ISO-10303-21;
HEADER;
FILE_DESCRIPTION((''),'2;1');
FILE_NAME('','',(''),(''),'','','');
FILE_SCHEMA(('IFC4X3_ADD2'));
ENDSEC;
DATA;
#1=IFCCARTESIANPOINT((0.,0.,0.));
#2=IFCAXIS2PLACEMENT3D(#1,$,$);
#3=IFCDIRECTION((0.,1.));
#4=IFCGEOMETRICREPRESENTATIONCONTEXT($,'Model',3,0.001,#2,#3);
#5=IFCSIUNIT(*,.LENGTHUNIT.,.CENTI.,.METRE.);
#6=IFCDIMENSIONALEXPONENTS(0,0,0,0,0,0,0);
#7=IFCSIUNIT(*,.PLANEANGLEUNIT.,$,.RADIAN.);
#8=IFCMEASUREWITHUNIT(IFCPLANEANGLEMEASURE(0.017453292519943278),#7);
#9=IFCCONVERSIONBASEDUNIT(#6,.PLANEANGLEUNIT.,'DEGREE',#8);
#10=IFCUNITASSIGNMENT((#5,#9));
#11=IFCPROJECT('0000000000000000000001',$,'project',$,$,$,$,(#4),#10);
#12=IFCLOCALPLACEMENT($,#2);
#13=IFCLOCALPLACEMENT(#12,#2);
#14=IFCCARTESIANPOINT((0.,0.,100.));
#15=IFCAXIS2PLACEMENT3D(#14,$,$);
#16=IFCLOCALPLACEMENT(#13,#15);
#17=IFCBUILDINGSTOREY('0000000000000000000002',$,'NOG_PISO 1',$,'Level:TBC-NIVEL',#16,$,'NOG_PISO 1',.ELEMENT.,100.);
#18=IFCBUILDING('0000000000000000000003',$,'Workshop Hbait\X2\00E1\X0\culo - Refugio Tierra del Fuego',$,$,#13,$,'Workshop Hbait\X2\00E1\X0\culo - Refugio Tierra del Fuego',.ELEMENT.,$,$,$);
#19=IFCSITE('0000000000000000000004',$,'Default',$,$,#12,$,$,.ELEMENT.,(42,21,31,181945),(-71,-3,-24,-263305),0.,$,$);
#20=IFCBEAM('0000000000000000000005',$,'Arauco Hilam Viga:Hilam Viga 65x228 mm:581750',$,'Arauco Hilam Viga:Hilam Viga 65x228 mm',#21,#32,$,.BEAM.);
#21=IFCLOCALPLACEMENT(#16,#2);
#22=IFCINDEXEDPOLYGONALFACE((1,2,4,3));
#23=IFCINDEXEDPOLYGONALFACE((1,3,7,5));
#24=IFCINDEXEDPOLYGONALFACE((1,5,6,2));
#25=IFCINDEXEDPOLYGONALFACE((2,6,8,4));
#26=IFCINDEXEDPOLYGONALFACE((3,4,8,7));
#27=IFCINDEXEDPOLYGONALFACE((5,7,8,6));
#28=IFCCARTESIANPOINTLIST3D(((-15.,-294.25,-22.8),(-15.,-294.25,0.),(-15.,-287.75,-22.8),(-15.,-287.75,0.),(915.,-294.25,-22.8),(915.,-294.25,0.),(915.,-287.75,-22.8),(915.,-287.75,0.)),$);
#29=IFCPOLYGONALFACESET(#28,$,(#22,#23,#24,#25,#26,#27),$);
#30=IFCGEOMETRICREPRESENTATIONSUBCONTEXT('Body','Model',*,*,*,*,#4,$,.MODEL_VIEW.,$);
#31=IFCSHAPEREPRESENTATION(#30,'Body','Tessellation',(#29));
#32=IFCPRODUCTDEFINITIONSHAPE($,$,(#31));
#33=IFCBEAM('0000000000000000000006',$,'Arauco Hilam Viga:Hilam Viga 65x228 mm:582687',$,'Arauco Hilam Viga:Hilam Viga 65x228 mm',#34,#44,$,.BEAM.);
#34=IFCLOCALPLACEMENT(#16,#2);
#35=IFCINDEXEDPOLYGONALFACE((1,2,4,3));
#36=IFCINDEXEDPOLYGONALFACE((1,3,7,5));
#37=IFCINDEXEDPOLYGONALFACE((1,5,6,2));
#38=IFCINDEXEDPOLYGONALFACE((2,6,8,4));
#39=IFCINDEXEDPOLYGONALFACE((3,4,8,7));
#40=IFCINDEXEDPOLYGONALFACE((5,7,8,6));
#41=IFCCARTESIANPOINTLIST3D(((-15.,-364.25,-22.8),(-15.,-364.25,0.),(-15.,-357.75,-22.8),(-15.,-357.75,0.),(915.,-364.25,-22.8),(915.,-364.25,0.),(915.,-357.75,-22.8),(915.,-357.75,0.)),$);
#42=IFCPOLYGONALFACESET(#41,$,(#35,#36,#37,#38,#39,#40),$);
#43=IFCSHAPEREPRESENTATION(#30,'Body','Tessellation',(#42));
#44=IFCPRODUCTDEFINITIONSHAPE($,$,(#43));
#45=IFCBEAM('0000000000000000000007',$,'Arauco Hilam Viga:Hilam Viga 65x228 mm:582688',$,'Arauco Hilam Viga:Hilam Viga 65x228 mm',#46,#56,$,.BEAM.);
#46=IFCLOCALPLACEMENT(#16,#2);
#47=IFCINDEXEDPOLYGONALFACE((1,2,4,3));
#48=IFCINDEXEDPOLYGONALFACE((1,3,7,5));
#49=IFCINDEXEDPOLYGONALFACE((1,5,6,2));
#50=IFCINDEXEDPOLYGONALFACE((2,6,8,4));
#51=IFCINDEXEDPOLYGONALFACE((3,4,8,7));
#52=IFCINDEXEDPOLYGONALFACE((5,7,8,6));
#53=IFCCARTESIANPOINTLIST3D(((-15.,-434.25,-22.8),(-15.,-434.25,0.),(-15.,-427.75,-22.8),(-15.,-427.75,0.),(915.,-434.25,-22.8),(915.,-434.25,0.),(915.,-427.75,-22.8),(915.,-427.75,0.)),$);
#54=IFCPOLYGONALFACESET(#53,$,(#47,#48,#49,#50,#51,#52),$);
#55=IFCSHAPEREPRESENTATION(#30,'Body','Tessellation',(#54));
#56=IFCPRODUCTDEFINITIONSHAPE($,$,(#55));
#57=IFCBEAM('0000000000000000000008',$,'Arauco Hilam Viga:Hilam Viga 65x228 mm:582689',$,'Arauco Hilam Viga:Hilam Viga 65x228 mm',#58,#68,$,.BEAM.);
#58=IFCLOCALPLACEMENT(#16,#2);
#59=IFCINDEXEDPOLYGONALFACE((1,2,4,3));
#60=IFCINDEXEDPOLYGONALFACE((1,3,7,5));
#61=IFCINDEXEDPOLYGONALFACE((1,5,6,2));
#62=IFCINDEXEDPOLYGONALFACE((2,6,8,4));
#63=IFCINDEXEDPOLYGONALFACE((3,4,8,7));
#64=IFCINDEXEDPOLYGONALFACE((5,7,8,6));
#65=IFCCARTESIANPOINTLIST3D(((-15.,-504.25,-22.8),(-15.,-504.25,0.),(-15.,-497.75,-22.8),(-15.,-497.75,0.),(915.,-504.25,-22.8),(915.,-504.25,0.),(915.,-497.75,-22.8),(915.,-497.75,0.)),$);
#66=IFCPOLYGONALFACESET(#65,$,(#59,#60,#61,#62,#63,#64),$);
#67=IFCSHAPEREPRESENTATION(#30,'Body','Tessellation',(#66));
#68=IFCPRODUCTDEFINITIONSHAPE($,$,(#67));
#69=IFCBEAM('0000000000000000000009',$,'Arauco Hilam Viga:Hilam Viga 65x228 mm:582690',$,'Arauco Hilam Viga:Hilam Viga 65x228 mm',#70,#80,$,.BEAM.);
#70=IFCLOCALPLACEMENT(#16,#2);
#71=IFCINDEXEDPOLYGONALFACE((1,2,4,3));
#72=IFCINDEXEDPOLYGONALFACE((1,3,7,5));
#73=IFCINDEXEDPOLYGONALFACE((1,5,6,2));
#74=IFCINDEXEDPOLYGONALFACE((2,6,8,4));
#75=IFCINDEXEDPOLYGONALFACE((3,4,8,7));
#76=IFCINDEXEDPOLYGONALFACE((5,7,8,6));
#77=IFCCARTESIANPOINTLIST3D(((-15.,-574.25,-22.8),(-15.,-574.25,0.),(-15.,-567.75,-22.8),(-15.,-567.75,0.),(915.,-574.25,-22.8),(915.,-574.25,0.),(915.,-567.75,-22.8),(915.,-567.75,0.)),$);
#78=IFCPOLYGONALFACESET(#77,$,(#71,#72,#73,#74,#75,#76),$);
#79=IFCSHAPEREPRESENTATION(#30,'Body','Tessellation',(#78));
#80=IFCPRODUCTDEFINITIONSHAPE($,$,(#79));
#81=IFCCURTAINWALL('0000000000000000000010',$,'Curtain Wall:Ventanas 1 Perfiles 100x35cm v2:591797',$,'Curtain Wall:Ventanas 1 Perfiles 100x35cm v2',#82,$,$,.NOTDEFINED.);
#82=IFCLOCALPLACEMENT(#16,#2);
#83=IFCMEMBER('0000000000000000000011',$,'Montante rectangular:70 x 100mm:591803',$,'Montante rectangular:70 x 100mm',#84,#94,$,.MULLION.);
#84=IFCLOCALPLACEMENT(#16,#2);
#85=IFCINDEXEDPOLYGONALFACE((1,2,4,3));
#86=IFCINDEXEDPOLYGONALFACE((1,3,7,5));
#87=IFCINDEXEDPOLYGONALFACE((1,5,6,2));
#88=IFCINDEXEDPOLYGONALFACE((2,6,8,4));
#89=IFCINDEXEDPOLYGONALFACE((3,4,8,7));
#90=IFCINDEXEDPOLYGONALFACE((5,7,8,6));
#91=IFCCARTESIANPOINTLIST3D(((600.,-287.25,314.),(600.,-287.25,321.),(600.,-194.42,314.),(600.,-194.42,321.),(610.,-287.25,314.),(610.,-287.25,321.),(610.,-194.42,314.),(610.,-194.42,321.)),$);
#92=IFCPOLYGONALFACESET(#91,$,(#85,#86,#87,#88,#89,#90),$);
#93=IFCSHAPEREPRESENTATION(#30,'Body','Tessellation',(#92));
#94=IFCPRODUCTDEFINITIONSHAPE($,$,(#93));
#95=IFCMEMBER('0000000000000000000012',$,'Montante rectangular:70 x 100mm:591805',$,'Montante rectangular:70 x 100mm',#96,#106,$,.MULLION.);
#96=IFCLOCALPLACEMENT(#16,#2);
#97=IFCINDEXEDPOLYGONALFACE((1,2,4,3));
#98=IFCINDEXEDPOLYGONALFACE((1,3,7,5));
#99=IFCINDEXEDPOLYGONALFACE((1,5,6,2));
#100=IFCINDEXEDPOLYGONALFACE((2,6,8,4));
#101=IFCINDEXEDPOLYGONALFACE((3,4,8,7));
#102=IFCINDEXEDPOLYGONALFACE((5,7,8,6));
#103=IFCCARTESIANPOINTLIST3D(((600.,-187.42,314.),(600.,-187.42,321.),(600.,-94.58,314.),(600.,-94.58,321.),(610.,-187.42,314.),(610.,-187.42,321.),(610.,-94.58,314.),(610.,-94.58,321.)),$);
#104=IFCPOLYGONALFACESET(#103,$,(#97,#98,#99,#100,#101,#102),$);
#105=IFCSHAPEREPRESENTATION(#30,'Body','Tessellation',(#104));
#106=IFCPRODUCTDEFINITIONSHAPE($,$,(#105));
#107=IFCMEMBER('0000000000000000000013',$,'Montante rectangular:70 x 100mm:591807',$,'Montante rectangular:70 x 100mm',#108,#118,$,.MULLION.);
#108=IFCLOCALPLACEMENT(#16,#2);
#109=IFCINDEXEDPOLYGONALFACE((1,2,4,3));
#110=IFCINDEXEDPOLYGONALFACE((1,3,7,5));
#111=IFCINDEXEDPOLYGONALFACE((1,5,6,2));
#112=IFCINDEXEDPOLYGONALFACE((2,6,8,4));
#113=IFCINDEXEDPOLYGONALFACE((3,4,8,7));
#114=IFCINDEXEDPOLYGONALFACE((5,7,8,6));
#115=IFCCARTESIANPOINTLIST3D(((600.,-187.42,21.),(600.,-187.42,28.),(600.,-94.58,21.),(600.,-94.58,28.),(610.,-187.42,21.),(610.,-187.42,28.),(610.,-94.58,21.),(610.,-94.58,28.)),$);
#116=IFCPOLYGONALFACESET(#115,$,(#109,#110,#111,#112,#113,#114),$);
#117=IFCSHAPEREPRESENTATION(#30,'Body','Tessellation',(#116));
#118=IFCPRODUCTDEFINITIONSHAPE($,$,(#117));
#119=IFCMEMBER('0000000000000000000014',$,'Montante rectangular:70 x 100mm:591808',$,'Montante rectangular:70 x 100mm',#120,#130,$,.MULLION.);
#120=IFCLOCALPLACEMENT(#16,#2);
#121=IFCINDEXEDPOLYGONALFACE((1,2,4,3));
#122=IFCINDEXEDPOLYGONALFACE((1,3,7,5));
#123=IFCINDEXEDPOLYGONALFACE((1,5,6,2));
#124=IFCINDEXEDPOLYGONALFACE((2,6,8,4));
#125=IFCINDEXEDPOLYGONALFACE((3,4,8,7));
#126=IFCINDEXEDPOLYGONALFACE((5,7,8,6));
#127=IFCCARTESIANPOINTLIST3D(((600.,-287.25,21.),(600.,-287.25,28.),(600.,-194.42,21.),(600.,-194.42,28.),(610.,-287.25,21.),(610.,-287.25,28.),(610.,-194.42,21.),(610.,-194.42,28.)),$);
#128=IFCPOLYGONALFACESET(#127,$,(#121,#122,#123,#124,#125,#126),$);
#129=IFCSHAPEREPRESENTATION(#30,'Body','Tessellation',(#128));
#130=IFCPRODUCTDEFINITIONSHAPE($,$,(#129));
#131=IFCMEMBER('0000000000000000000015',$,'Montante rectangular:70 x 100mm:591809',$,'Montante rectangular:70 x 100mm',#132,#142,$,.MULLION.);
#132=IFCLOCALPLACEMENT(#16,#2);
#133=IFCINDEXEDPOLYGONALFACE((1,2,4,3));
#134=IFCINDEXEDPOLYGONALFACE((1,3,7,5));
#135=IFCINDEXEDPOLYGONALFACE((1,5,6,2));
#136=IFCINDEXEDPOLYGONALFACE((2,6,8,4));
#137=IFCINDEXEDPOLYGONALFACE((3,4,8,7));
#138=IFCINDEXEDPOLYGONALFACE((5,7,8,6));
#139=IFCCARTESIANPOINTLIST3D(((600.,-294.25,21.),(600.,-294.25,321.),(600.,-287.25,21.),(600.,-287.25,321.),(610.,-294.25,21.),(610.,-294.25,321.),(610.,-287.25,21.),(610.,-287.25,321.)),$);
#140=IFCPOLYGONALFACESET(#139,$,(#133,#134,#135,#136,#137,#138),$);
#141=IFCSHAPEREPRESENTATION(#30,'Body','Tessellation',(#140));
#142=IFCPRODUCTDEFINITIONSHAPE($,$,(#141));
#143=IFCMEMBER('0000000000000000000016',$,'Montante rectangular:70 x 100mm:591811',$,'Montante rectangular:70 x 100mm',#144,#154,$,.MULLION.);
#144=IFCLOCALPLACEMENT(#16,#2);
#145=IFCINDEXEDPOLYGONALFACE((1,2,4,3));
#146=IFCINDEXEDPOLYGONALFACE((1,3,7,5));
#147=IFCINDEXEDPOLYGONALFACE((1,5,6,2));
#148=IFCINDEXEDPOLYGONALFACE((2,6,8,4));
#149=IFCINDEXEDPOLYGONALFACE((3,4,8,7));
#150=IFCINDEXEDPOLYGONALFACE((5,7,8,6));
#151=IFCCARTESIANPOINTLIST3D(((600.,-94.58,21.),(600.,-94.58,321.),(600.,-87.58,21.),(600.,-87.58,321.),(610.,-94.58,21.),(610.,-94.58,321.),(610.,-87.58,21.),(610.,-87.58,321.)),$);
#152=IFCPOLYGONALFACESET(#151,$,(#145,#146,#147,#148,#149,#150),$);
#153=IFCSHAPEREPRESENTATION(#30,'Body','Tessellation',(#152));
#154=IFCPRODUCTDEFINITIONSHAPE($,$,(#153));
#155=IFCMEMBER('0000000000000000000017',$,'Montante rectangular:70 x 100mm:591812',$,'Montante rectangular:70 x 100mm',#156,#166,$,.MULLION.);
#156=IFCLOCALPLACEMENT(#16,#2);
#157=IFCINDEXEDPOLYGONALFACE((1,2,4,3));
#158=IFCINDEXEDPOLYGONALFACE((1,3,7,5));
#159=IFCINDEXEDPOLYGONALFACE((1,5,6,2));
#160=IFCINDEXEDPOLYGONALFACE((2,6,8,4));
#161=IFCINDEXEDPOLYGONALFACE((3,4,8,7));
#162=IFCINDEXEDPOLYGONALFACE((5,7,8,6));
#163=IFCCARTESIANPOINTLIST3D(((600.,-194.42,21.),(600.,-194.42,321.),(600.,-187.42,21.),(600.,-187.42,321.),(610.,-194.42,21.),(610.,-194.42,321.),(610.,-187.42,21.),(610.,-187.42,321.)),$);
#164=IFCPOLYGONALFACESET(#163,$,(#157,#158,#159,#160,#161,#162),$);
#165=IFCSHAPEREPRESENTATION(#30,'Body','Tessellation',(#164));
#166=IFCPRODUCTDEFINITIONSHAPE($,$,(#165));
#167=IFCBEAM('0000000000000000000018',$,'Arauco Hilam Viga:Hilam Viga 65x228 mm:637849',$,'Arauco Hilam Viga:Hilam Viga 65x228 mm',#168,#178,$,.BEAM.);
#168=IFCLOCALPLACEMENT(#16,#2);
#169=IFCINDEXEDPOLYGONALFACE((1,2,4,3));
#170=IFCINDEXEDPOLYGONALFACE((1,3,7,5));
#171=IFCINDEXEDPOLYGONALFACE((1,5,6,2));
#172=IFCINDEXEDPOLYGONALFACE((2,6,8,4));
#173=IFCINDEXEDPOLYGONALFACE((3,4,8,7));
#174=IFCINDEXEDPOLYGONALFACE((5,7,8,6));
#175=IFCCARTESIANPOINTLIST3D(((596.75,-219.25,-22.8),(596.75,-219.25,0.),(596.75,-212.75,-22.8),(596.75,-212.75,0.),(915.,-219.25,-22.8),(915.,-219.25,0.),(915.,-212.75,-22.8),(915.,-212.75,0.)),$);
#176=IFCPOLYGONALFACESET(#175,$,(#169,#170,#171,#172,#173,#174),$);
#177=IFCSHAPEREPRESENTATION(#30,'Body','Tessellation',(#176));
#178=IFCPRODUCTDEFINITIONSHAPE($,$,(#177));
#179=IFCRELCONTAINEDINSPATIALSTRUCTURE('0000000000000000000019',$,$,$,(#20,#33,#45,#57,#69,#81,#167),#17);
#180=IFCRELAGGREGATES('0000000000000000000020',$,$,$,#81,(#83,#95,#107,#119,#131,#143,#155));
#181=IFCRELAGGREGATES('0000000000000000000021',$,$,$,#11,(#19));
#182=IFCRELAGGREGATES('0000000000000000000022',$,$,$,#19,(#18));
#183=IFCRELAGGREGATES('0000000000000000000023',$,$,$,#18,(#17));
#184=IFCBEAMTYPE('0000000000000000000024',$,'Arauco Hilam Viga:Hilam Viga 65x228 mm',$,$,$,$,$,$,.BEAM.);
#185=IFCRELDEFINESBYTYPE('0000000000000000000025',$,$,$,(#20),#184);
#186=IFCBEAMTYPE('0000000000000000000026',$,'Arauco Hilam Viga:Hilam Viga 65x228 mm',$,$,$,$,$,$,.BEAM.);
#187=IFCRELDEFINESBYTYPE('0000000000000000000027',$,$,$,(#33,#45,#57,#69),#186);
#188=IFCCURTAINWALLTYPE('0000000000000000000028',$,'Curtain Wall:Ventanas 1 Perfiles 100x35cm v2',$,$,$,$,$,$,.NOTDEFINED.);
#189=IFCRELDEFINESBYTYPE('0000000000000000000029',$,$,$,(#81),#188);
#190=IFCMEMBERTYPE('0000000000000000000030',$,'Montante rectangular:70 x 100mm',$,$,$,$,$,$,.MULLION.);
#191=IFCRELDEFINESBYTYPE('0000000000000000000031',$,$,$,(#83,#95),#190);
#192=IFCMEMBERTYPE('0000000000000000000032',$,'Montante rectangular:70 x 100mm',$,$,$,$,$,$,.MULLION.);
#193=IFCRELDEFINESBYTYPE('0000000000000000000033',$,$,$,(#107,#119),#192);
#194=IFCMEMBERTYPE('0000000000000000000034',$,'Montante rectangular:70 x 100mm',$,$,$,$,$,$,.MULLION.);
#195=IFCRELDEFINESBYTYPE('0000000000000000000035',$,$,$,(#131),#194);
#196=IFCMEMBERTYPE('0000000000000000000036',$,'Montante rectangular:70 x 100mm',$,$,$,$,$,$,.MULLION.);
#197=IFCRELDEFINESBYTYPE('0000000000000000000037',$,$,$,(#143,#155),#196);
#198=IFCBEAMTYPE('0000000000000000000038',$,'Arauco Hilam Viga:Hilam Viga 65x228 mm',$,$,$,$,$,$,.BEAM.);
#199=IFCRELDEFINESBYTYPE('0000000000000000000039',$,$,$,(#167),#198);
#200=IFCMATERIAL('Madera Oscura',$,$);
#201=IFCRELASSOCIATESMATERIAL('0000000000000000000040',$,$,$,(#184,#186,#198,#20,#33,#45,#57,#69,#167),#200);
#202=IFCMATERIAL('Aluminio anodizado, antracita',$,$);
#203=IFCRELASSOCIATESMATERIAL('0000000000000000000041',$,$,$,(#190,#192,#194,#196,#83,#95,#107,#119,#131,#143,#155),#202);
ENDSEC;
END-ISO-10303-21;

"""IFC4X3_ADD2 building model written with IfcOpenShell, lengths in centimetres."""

from ifc_helpers import new_model, entity, si_unit, converted_unit, direction, frame, frame_2d, origin, origin_2d_with_axis, place, context, subcontext, project, spatial, rectangle, extrude, source, transform, mapped, material, material_profile, profile_set, profile_usage, type_object, type_shapes, element, aggregate, save


model = new_model("IFC4X3_ADD2")

# Units and contexts
model_context = context("Model", 3, precision=0.001, world=origin(), true_north=direction((0.0, 1.0)))
body_context = subcontext(model_context, "Body", "Model", "MODEL_VIEW")
ifc_project = project(units=[si_unit("LENGTHUNIT", "METRE", prefix="CENTI"), converted_unit("PLANEANGLEUNIT", "DEGREE", entity("IfcPlaneAngleMeasure", 0.017453292519943278), si_unit("PLANEANGLEUNIT", "RADIAN"), dimensions=[0, 0, 0, 0, 0, 0, 0])], contexts=[model_context])

# Site, building, storey
site_placement = place(None, origin())
site = spatial("IfcSite", under=ifc_project, at=site_placement, Name="Default", CompositionType="ELEMENT", RefLatitude=(42, 21, 31, 181945), RefLongitude=(-71, -3, -24, -263305), RefElevation=0.0)
building_placement = place(site_placement, origin())
building = spatial("IfcBuilding", under=site, at=building_placement, Name="Workshop Hbaitáculo - Refugio Tierra del Fuego", LongName="Workshop Hbaitáculo - Refugio Tierra del Fuego", CompositionType="ELEMENT")
storey_placement = place(building_placement, frame((0.0, 0.0, 100.0)))
storey = spatial("IfcBuildingStorey", under=building, at=storey_placement, Name="NOG_PISO 1", ObjectType="Level:TBC-NIVEL", LongName="NOG_PISO 1", CompositionType="ELEMENT", Elevation=100.0)

# Beams
ifc_material_1 = material(Name="Madera Oscura")
ifc_material_profile_1 = material_profile(ifc_material_1, rectangle(XDim=930.0, YDim=6.5, at=origin_2d_with_axis()), Name="Hilam Viga 65x228 mm")
ifc_profile_set_1 = profile_set([ifc_material_profile_1], Name="Hilam Viga 65x228 mm")
ifc_profile_usage_1 = profile_usage(ifc_profile_set_1, cardinal=8)
beam_type_1 = type_object("IfcBeamType", Name="Arauco Hilam Viga:Hilam Viga 65x228 mm", PredefinedType="BEAM", material=ifc_profile_set_1)
shared_shape_1 = source(origin(), body_context, "Body", "SweptSolid", [
    extrude(rectangle(XDim=930.0, YDim=6.5, at=origin_2d_with_axis()), frame((15.63, 0.0, -11.4), z_axis=(0.0, 0.0, 1.0), x_axis=(-1.0, 0.0, 0.0)), (0.0, 0.0, 1.0), 22.8),
])
type_shapes(beam_type_1, [shared_shape_1])
beam_1_placement = place(storey_placement, frame((434.37, -291.0, -11.4)))
element("IfcBeam", 1, at=beam_1_placement, inside=storey, type_object=beam_type_1, material=ifc_profile_usage_1, Name="Arauco Hilam Viga:Hilam Viga 65x228 mm:581750", ObjectType="Arauco Hilam Viga:Hilam Viga 65x228 mm", PredefinedType="BEAM", context=body_context, shape_type="MappedRepresentation", body=[
    mapped(shared_shape_1, transform((0.0, 0.0, 0.0), scale=1.0)),
])
beam_type_2 = type_object("IfcBeamType", Name="Arauco Hilam Viga:Hilam Viga 65x228 mm", PredefinedType="BEAM", material=ifc_profile_set_1)
shared_shape_2 = source(origin(), body_context, "Body", "SweptSolid", [
    extrude(rectangle(XDim=6.5, YDim=930.0, at=origin_2d_with_axis()), frame((15.63, 0.0, -11.4), z_axis=(0.0, 0.0, 1.0), x_axis=(0.0, 1.0, 0.0)), (0.0, 0.0, 1.0), 22.8),
])
type_shapes(beam_type_2, [shared_shape_2])
for number, where, name in (
    (2, (434.37, -361.0, -11.4), "Arauco Hilam Viga:Hilam Viga 65x228 mm:582687"),
    (3, (434.37, -431.0, -11.4), "Arauco Hilam Viga:Hilam Viga 65x228 mm:582688"),
    (4, (434.37, -501.0, -11.4), "Arauco Hilam Viga:Hilam Viga 65x228 mm:582689"),
    (5, (434.37, -571.0, -11.4), "Arauco Hilam Viga:Hilam Viga 65x228 mm:582690"),
):
    element("IfcBeam", number, at=place(storey_placement, frame(where)), inside=storey, type_object=beam_type_2, material=ifc_profile_usage_1, Name=name, ObjectType="Arauco Hilam Viga:Hilam Viga 65x228 mm", PredefinedType="BEAM", context=body_context, shape_type="MappedRepresentation", body=[
        mapped(shared_shape_2, transform((0.0, 0.0, 0.0), scale=1.0)),
    ])

# Curtain wall, members
curtain_wall_type = type_object("IfcCurtainWallType", Name="Curtain Wall:Ventanas 1 Perfiles 100x35cm v2", PredefinedType="NOTDEFINED")
curtain_wall_placement = place(storey_placement, frame((0.0, 0.0, -100.0)))
curtain_wall = element("IfcCurtainWall", 6, at=curtain_wall_placement, inside=storey, type_object=curtain_wall_type, Name="Curtain Wall:Ventanas 1 Perfiles 100x35cm v2:591797", ObjectType="Curtain Wall:Ventanas 1 Perfiles 100x35cm v2", PredefinedType="NOTDEFINED")
ifc_material_2 = material(Name="Aluminio anodizado, antracita")
ifc_material_profile_2 = material_profile(ifc_material_2, rectangle(XDim=7.0, YDim=10.0, at=origin_2d_with_axis()), Name="70 x 100mm")
ifc_profile_set_2 = profile_set([ifc_material_profile_2], Name="70 x 100mm")
ifc_profile_usage_2 = profile_usage(ifc_profile_set_2)
member_type_1 = type_object("IfcMemberType", Name="Montante rectangular:70 x 100mm", PredefinedType="MULLION", material=ifc_profile_set_2)
shared_shape_3 = source(origin(), body_context, "Body", "SweptSolid", [
    extrude(rectangle(XDim=7.0, YDim=10.0, at=origin_2d_with_axis()), frame((-3.5, 0.0, -92.83), z_axis=(0.0, 0.0, 1.0), x_axis=(-1.0, 0.0, 0.0)), (0.0, 0.0, 1.0), 92.83),
])
type_shapes(member_type_1, [shared_shape_3])
member_1_placement = place(curtain_wall_placement, frame((605.0, -287.25, 421.0), z_axis=(0.0, -1.0, 0.0), x_axis=(0.0, 0.0, 1.0)))
member_1 = element("IfcMember", 7, at=member_1_placement, type_object=member_type_1, material=ifc_profile_usage_2, Name="Montante rectangular:70 x 100mm:591803", ObjectType="Montante rectangular:70 x 100mm", PredefinedType="MULLION", context=body_context, shape_type="MappedRepresentation", body=[
    mapped(shared_shape_3, transform((0.0, 0.0, 0.0), scale=1.0)),
])
member_2_placement = place(curtain_wall_placement, frame((605.0, -187.42, 421.0), z_axis=(0.0, -1.0, 0.0), x_axis=(0.0, 0.0, 1.0)))
member_2 = element("IfcMember", 8, at=member_2_placement, type_object=member_type_1, material=ifc_profile_usage_2, Name="Montante rectangular:70 x 100mm:591805", ObjectType="Montante rectangular:70 x 100mm", PredefinedType="MULLION", context=body_context, shape_type="MappedRepresentation", body=[
    mapped(shared_shape_3, transform((0.0, 0.0, 0.0), scale=1.0)),
])
member_type_2 = type_object("IfcMemberType", Name="Montante rectangular:70 x 100mm", PredefinedType="MULLION", material=ifc_profile_set_2)
shared_shape_4 = source(origin(), body_context, "Body", "SweptSolid", [
    extrude(rectangle(XDim=7.0, YDim=10.0, at=origin_2d_with_axis()), frame((-3.5, 0.0, -92.83), z_axis=(0.0, 0.0, 1.0), x_axis=(-1.0, 0.0, 0.0)), (0.0, 0.0, 1.0), 92.83),
])
type_shapes(member_type_2, [shared_shape_4])
member_3_placement = place(curtain_wall_placement, frame((605.0, -94.58, 121.0), z_axis=(0.0, 1.0, 0.0), x_axis=(0.0, 0.0, -1.0)))
member_3 = element("IfcMember", 9, at=member_3_placement, type_object=member_type_2, material=ifc_profile_usage_2, Name="Montante rectangular:70 x 100mm:591807", ObjectType="Montante rectangular:70 x 100mm", PredefinedType="MULLION", context=body_context, shape_type="MappedRepresentation", body=[
    mapped(shared_shape_4, transform((0.0, 0.0, 0.0), scale=1.0)),
])
member_4_placement = place(curtain_wall_placement, frame((605.0, -194.42, 121.0), z_axis=(0.0, 1.0, 0.0), x_axis=(0.0, 0.0, -1.0)))
member_4 = element("IfcMember", 10, at=member_4_placement, type_object=member_type_2, material=ifc_profile_usage_2, Name="Montante rectangular:70 x 100mm:591808", ObjectType="Montante rectangular:70 x 100mm", PredefinedType="MULLION", context=body_context, shape_type="MappedRepresentation", body=[
    mapped(shared_shape_4, transform((0.0, 0.0, 0.0), scale=1.0)),
])
member_type_3 = type_object("IfcMemberType", Name="Montante rectangular:70 x 100mm", PredefinedType="MULLION", material=ifc_profile_set_2)
shared_shape_5 = source(origin(), body_context, "Body", "SweptSolid", [
    extrude(rectangle(XDim=7.0, YDim=10.0, at=origin_2d_with_axis()), frame((-3.5, 0.0, -300.0), z_axis=(0.0, 0.0, 1.0), x_axis=(-1.0, 0.0, 0.0)), (0.0, 0.0, 1.0), 300.0),
])
type_shapes(member_type_3, [shared_shape_5])
member_5_placement = place(curtain_wall_placement, frame((605.0, -294.25, 121.0), z_axis=(0.0, 0.0, -1.0), x_axis=(0.0, -1.0, 0.0)))
member_5 = element("IfcMember", 11, at=member_5_placement, type_object=member_type_3, material=ifc_profile_usage_2, Name="Montante rectangular:70 x 100mm:591809", ObjectType="Montante rectangular:70 x 100mm", PredefinedType="MULLION", context=body_context, shape_type="MappedRepresentation", body=[
    mapped(shared_shape_5, transform((0.0, 0.0, 0.0), scale=1.0)),
])
member_type_4 = type_object("IfcMemberType", Name="Montante rectangular:70 x 100mm", PredefinedType="MULLION", material=ifc_profile_set_2)
shared_shape_6 = source(origin(), body_context, "Body", "SweptSolid", [
    extrude(rectangle(XDim=7.0, YDim=10.0, at=frame_2d((0.0, 0.0), x_axis=(1.0, 0.0))), frame((0.0, 0.0, -300.0), z_axis=(0.0, 0.0, 1.0), x_axis=(-1.0, 0.0, 0.0)), (0.0, 0.0, 1.0), 300.0),
])
type_shapes(member_type_4, [shared_shape_6])
member_6_placement = place(curtain_wall_placement, frame((605.0, -91.08, 121.0), z_axis=(0.0, 0.0, -1.0), x_axis=(0.0, -1.0, 0.0)))
member_6 = element("IfcMember", 12, at=member_6_placement, type_object=member_type_4, material=ifc_profile_usage_2, Name="Montante rectangular:70 x 100mm:591811", ObjectType="Montante rectangular:70 x 100mm", PredefinedType="MULLION", context=body_context, shape_type="MappedRepresentation", body=[
    mapped(shared_shape_6, transform((0.0, 0.0, 0.0), scale=1.0)),
])
member_7_placement = place(curtain_wall_placement, frame((605.0, -190.92, 121.0), z_axis=(0.0, 0.0, -1.0), x_axis=(0.0, -1.0, 0.0)))
member_7 = element("IfcMember", 13, at=member_7_placement, type_object=member_type_4, material=ifc_profile_usage_2, Name="Montante rectangular:70 x 100mm:591812", ObjectType="Montante rectangular:70 x 100mm", PredefinedType="MULLION", context=body_context, shape_type="MappedRepresentation", body=[
    mapped(shared_shape_6, transform((0.0, 0.0, 0.0), scale=1.0)),
])

# Beam
beam_type_3 = type_object("IfcBeamType", Name="Arauco Hilam Viga:Hilam Viga 65x228 mm", PredefinedType="BEAM", material=ifc_profile_set_1)
shared_shape_7 = source(origin(), body_context, "Body", "SweptSolid", [
    extrude(rectangle(XDim=318.25, YDim=6.5, at=origin_2d_with_axis()), frame((0.0, 0.0, -11.4), z_axis=(0.0, 0.0, 1.0), x_axis=(-1.0, 0.0, 0.0)), (0.0, 0.0, 1.0), 22.8),
])
type_shapes(beam_type_3, [shared_shape_7])
beam_2_placement = place(storey_placement, frame((755.88, -216.0, -11.4)))
element("IfcBeam", 14, at=beam_2_placement, inside=storey, type_object=beam_type_3, material=ifc_profile_usage_1, Name="Arauco Hilam Viga:Hilam Viga 65x228 mm:637849", ObjectType="Arauco Hilam Viga:Hilam Viga 65x228 mm", PredefinedType="BEAM", context=body_context, shape_type="MappedRepresentation", body=[
    mapped(shared_shape_7, transform((0.0, 0.0, 0.0), scale=1.0)),
])

aggregate(curtain_wall, [member_1, member_2, member_3, member_4, member_5, member_6, member_7])

save(model, "model.ifc")
